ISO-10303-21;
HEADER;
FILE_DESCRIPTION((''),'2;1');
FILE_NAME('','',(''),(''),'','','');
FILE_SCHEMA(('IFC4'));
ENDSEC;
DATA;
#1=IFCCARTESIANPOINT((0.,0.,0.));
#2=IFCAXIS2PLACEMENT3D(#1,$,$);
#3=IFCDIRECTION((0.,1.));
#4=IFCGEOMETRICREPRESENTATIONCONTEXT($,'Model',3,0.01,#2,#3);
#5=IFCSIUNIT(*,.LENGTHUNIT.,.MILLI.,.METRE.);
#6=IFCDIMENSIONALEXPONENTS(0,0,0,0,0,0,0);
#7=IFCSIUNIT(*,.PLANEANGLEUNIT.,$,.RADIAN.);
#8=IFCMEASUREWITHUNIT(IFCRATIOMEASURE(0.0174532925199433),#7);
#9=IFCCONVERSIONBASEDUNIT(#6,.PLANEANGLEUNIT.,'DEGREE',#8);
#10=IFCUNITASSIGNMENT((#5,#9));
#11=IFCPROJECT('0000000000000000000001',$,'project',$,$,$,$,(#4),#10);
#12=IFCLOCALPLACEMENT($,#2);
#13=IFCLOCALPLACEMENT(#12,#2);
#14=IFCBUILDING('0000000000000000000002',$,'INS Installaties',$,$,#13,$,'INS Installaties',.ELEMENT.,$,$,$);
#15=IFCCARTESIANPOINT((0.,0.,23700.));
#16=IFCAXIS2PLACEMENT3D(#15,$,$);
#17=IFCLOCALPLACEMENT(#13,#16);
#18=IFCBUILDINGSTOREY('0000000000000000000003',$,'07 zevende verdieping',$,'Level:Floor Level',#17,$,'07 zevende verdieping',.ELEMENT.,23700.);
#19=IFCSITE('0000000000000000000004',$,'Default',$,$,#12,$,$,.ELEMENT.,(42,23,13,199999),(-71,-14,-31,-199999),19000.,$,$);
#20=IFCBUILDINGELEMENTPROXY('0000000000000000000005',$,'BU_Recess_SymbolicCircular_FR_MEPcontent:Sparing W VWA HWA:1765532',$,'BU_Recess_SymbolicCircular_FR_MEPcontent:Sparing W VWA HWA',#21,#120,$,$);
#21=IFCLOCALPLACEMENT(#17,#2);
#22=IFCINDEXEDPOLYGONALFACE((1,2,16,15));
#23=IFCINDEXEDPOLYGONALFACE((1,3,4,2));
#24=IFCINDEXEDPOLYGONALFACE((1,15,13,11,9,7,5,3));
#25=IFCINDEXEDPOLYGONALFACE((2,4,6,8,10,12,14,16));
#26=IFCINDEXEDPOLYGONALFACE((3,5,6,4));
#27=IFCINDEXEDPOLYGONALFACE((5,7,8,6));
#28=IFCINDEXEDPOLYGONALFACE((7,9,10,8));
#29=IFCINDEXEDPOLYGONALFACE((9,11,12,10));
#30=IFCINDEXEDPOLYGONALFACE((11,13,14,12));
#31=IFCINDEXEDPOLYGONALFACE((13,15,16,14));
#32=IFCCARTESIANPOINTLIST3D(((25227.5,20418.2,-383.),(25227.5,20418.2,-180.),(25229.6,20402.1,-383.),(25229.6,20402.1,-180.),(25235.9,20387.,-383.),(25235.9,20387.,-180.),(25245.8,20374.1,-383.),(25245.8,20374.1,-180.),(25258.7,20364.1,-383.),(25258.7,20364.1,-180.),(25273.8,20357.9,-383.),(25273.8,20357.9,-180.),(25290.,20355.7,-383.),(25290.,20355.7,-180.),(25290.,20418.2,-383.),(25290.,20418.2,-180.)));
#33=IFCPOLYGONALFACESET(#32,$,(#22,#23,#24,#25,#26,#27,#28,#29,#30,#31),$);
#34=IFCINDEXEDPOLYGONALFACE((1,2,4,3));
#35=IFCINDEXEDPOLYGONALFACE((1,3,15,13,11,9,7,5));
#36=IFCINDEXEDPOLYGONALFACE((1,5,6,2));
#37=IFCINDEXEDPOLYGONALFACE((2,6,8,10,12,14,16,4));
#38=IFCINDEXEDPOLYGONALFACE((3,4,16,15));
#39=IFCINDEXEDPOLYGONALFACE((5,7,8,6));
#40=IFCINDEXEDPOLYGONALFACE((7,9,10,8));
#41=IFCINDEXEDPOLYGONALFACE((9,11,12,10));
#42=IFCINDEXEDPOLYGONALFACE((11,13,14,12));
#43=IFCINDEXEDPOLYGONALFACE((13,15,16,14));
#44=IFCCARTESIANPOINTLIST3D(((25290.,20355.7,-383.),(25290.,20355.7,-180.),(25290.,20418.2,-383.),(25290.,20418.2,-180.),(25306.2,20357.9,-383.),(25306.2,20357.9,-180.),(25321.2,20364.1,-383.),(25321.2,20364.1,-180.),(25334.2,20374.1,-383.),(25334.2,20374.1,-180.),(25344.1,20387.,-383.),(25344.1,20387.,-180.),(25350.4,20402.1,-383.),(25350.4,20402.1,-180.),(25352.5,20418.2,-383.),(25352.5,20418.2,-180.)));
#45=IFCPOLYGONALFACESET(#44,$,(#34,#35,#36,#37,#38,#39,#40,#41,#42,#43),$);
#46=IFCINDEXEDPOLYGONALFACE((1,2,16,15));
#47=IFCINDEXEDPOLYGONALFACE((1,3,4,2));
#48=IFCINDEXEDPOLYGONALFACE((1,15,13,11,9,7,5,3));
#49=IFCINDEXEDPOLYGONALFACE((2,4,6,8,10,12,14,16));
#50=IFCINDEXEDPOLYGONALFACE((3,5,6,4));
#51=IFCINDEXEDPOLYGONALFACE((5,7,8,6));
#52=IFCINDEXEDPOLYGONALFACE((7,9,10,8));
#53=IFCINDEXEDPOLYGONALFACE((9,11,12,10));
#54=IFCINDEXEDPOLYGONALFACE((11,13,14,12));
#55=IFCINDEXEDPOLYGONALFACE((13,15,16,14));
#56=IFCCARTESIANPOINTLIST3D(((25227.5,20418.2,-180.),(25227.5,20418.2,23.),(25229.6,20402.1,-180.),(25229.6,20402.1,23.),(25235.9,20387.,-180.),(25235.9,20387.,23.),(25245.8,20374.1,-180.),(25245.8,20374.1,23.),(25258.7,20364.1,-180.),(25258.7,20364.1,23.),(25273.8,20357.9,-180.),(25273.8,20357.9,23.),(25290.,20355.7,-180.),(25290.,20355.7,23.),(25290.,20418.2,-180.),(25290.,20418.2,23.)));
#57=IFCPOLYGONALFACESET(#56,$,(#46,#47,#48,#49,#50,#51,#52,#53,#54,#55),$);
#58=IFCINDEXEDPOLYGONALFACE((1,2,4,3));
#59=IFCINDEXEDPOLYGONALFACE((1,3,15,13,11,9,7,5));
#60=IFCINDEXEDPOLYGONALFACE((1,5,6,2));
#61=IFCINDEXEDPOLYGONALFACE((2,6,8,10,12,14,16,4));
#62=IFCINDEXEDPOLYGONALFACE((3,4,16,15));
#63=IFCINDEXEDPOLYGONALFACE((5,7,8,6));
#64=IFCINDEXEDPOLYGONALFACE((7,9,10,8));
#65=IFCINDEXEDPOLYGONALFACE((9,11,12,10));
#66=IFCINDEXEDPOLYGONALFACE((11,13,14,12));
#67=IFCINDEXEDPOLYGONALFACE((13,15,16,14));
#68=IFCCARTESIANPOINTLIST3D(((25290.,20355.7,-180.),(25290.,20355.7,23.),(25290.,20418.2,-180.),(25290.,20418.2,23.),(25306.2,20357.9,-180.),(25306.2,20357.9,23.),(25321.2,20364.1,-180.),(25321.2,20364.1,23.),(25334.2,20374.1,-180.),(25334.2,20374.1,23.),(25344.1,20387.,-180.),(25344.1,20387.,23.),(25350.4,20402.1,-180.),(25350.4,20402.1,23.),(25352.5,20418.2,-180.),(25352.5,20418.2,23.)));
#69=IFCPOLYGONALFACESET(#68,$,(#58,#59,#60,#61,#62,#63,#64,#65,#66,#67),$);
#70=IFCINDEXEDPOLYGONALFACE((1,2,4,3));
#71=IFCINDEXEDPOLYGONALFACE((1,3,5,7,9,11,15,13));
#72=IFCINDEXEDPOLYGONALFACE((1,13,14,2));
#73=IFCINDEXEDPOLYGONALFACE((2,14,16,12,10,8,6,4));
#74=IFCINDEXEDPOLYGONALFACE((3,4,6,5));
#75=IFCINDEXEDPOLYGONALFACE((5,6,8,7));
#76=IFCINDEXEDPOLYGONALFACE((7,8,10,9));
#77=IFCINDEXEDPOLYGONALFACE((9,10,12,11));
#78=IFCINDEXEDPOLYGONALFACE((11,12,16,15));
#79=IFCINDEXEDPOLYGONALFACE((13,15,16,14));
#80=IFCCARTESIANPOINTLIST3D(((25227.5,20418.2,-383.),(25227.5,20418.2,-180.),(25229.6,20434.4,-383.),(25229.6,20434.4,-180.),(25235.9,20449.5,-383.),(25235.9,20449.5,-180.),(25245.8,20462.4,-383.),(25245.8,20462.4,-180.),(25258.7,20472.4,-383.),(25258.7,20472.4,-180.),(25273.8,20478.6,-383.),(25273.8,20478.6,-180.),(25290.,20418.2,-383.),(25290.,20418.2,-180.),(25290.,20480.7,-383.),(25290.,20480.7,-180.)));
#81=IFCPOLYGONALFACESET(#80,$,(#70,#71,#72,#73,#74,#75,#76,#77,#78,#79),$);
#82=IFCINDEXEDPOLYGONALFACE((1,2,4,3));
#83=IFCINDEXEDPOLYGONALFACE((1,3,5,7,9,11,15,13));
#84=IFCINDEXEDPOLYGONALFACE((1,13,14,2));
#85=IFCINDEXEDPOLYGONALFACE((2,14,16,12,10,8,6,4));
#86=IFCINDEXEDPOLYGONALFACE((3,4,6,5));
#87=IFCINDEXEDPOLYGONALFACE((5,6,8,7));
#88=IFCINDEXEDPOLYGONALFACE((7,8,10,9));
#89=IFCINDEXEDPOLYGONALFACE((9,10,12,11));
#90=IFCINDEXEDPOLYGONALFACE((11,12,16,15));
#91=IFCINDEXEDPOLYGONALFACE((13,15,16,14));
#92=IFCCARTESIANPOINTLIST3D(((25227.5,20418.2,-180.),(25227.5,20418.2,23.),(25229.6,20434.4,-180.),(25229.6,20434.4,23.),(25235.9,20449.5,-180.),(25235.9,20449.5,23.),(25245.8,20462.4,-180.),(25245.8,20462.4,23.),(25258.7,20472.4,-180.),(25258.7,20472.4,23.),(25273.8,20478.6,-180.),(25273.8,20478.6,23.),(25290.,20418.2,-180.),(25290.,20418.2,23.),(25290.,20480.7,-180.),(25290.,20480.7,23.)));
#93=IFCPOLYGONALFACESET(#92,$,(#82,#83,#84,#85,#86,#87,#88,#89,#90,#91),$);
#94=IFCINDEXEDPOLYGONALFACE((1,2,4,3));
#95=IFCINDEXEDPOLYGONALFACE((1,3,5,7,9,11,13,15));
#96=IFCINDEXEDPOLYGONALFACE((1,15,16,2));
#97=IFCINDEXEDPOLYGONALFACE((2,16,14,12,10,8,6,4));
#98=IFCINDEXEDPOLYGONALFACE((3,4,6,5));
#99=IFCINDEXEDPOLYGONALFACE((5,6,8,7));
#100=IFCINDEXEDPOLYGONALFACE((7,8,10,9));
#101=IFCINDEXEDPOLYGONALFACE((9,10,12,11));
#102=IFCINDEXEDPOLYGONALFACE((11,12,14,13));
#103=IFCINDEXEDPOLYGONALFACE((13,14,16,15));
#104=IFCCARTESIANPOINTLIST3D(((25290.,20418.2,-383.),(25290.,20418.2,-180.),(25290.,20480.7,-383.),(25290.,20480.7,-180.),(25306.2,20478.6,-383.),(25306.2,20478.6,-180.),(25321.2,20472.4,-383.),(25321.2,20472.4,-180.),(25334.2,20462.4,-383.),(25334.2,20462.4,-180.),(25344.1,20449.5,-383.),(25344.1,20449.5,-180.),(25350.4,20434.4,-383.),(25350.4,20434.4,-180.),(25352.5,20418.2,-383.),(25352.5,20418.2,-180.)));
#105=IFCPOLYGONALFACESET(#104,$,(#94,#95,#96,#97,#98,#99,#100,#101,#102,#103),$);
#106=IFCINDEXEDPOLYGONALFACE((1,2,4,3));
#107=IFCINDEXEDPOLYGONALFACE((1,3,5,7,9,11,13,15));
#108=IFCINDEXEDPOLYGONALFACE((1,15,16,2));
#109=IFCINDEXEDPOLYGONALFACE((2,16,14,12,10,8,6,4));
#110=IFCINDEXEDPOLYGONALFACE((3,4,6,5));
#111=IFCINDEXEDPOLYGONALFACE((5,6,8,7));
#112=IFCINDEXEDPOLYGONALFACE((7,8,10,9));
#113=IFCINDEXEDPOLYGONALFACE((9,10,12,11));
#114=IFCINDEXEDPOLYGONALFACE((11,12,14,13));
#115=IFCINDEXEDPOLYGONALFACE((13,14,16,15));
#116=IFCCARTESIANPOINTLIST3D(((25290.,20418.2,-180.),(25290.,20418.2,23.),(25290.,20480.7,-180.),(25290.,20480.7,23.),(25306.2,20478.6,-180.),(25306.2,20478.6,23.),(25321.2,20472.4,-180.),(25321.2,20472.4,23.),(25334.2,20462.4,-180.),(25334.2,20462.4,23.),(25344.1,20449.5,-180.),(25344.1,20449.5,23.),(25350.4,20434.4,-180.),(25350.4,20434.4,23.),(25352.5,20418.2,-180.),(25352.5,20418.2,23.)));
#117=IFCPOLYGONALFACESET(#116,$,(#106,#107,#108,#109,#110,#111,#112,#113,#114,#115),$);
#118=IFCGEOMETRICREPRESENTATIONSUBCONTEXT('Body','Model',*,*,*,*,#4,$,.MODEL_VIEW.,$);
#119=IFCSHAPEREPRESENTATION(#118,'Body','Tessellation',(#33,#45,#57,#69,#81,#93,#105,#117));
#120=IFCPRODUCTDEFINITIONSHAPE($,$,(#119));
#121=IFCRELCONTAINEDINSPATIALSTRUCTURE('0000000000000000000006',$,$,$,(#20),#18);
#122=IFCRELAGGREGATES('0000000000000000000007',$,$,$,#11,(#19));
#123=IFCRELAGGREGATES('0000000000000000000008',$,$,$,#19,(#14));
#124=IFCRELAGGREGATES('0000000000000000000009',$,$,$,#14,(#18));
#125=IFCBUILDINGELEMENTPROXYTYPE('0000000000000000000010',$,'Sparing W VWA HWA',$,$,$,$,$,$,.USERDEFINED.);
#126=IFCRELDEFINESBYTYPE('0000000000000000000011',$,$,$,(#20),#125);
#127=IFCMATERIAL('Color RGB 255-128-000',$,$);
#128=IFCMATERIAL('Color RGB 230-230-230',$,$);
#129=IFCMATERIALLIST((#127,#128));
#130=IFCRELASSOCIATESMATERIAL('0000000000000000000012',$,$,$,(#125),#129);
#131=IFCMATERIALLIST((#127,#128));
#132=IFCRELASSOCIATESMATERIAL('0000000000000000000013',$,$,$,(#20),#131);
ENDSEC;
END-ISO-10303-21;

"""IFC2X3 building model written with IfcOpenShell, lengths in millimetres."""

from ifc_helpers import new_model, entity, si_unit, converted_unit, direction, frame, frame_2d, origin, place, context, subcontext, project, spatial, polyline, circle_curve, parameter, trimmed, segment, composite_curve, outline, extrude, source, transform, mapped, material, material_list, type_object, type_shapes, element, save


model = new_model("IFC2X3")

# Units and contexts
model_context = context("Model", 3, precision=0.01, world=origin(), true_north=direction((0.0, 1.0)))
body_context = subcontext(model_context, "Body", "Model", "MODEL_VIEW")
ifc_project = project(units=[si_unit("LENGTHUNIT", "METRE", prefix="MILLI"), converted_unit("PLANEANGLEUNIT", "DEGREE", entity("IfcRatioMeasure", 0.0174532925199433), si_unit("PLANEANGLEUNIT", "RADIAN"), dimensions=[0, 0, 0, 0, 0, 0, 0])], contexts=[model_context])

# Site, building, storey
site_placement = place(None, origin())
site = spatial("IfcSite", under=ifc_project, at=site_placement, Name="Default", CompositionType="ELEMENT", RefLatitude=(42, 23, 13, 199999), RefLongitude=(-71, -14, -31, -199999), RefElevation=19000.0)
building_placement = place(site_placement, origin())
building = spatial("IfcBuilding", under=site, at=building_placement, Name="INS Installaties", LongName="INS Installaties", CompositionType="ELEMENT")
storey_placement = place(building_placement, frame((0.0, 0.0, 23700.0)))
storey = spatial("IfcBuildingStorey", under=building, at=storey_placement, Name="07 zevende verdieping", ObjectType="Level:Floor Level", LongName="07 zevende verdieping", CompositionType="ELEMENT", Elevation=23700.0)

# Building element proxy
ifc_material_1 = material(Name="Color RGB 255-128-000")
ifc_material_2 = material(Name="Color RGB 230-230-230")
ifc_material_list_1 = material_list([ifc_material_1, ifc_material_2])
building_element_proxy_type_1 = type_object("IfcBuildingElementProxyType", Name="Sparing W VWA HWA", PredefinedType="USERDEFINED", material=ifc_material_list_1)
shared_shape_1 = source(origin(), body_context, "Body", "SweptSolid", [
    extrude(outline(composite_curve([segment(trimmed(circle_curve(frame_2d((20.8, 20.8), x_axis=(1.0, 0.0)), 62.5), [parameter(180.0)], [parameter(270.0)], True, "PARAMETER"), True, "CONTINUOUS"), segment(polyline([(20.8, -41.7), (20.8, 20.8)]), True, "CONTINUOUS"), segment(polyline([(20.8, 20.8), (-41.7, 20.8)]), True, "CONTINUOUS")], self_intersect=False)), frame((20.8, 20.8, -403.0), z_axis=(0.0, 0.0, 1.0), x_axis=(-1.0, 0.0, 0.0)), (0.0, 0.0, 1.0), 203.0),
    extrude(outline(composite_curve([segment(polyline([(-41.7, -20.8), (20.8, -20.8)]), True, "CONTINUOUS"), segment(polyline([(20.8, -20.8), (20.8, 41.7)]), True, "CONTINUOUS"), segment(trimmed(circle_curve(frame_2d((20.8, -20.8), x_axis=(1.0, 0.0)), 62.5), [parameter(90.0)], [parameter(180.0)], True, "PARAMETER"), True, "CONTINUOUS")], self_intersect=False)), frame((-20.8, 20.8, -403.0)), (0.0, 0.0, 1.0), 203.0),
    extrude(outline(composite_curve([segment(trimmed(circle_curve(frame_2d((20.8, 20.8), x_axis=(1.0, 0.0)), 62.5), [parameter(180.0)], [parameter(270.0)], True, "PARAMETER"), True, "CONTINUOUS"), segment(polyline([(20.8, -41.7), (20.8, 20.8)]), True, "CONTINUOUS"), segment(polyline([(20.8, 20.8), (-41.7, 20.8)]), True, "CONTINUOUS")], self_intersect=False)), frame((20.8, 20.8, -200.0), z_axis=(0.0, 0.0, 1.0), x_axis=(-1.0, 0.0, 0.0)), (0.0, 0.0, 1.0), 203.0),
    extrude(outline(composite_curve([segment(polyline([(-41.7, -20.8), (20.8, -20.8)]), True, "CONTINUOUS"), segment(polyline([(20.8, -20.8), (20.8, 41.7)]), True, "CONTINUOUS"), segment(trimmed(circle_curve(frame_2d((20.8, -20.8), x_axis=(1.0, 0.0)), 62.5), [parameter(90.0)], [parameter(180.0)], True, "PARAMETER"), True, "CONTINUOUS")], self_intersect=False)), frame((-20.8, 20.8, -200.0)), (0.0, 0.0, 1.0), 203.0),
    extrude(outline(composite_curve([segment(polyline([(-41.7, -20.8), (20.8, -20.8)]), True, "CONTINUOUS"), segment(polyline([(20.8, -20.8), (20.8, 41.7)]), True, "CONTINUOUS"), segment(trimmed(circle_curve(frame_2d((20.8, -20.8), x_axis=(1.0, 0.0)), 62.5), [parameter(90.0)], [parameter(180.0)], True, "PARAMETER"), True, "CONTINUOUS")], self_intersect=False)), frame((20.8, -20.8, -403.0), z_axis=(0.0, 0.0, 1.0), x_axis=(-1.0, 0.0, 0.0)), (0.0, 0.0, 1.0), 203.0),
    extrude(outline(composite_curve([segment(polyline([(-41.7, -20.8), (20.8, -20.8)]), True, "CONTINUOUS"), segment(polyline([(20.8, -20.8), (20.8, 41.7)]), True, "CONTINUOUS"), segment(trimmed(circle_curve(frame_2d((20.8, -20.8), x_axis=(1.0, 0.0)), 62.5), [parameter(90.0)], [parameter(180.0)], True, "PARAMETER"), True, "CONTINUOUS")], self_intersect=False)), frame((20.8, -20.8, -200.0), z_axis=(0.0, 0.0, 1.0), x_axis=(-1.0, 0.0, 0.0)), (0.0, 0.0, 1.0), 203.0),
    extrude(outline(composite_curve([segment(trimmed(circle_curve(frame_2d((20.8, 20.8), x_axis=(1.0, 0.0)), 62.5), [parameter(180.0)], [parameter(270.0)], True, "PARAMETER"), True, "CONTINUOUS"), segment(polyline([(20.8, -41.7), (20.8, 20.8)]), True, "CONTINUOUS"), segment(polyline([(20.8, 20.8), (-41.7, 20.8)]), True, "CONTINUOUS")], self_intersect=False)), frame((-20.8, -20.8, -403.0)), (0.0, 0.0, 1.0), 203.0),
    extrude(outline(composite_curve([segment(trimmed(circle_curve(frame_2d((20.8, 20.8), x_axis=(1.0, 0.0)), 62.5), [parameter(180.0)], [parameter(270.0)], True, "PARAMETER"), True, "CONTINUOUS"), segment(polyline([(20.8, -41.7), (20.8, 20.8)]), True, "CONTINUOUS"), segment(polyline([(20.8, 20.8), (-41.7, 20.8)]), True, "CONTINUOUS")], self_intersect=False)), frame((-20.8, -20.8, -200.0)), (0.0, 0.0, 1.0), 203.0),
])
type_shapes(building_element_proxy_type_1, [shared_shape_1])
ifc_material_list_2 = material_list([ifc_material_1, ifc_material_2])
proxy_1_placement = place(storey_placement, frame((25290.0, 20418.2, 20.0), z_axis=(0.0, 0.0, 1.0), x_axis=(-1.0, 0.0, 0.0)))
element("IfcBuildingElementProxy", 1, at=proxy_1_placement, inside=storey, type_object=building_element_proxy_type_1, material=ifc_material_list_2, Name="BU_Recess_SymbolicCircular_FR_MEPcontent:Sparing W VWA HWA:1765532", ObjectType="BU_Recess_SymbolicCircular_FR_MEPcontent:Sparing W VWA HWA", context=body_context, shape_type="MappedRepresentation", body=[
    mapped(shared_shape_1, transform((0.0, 0.0, 0.0), scale=1.0)),
])

save(model, "model.ifc")
